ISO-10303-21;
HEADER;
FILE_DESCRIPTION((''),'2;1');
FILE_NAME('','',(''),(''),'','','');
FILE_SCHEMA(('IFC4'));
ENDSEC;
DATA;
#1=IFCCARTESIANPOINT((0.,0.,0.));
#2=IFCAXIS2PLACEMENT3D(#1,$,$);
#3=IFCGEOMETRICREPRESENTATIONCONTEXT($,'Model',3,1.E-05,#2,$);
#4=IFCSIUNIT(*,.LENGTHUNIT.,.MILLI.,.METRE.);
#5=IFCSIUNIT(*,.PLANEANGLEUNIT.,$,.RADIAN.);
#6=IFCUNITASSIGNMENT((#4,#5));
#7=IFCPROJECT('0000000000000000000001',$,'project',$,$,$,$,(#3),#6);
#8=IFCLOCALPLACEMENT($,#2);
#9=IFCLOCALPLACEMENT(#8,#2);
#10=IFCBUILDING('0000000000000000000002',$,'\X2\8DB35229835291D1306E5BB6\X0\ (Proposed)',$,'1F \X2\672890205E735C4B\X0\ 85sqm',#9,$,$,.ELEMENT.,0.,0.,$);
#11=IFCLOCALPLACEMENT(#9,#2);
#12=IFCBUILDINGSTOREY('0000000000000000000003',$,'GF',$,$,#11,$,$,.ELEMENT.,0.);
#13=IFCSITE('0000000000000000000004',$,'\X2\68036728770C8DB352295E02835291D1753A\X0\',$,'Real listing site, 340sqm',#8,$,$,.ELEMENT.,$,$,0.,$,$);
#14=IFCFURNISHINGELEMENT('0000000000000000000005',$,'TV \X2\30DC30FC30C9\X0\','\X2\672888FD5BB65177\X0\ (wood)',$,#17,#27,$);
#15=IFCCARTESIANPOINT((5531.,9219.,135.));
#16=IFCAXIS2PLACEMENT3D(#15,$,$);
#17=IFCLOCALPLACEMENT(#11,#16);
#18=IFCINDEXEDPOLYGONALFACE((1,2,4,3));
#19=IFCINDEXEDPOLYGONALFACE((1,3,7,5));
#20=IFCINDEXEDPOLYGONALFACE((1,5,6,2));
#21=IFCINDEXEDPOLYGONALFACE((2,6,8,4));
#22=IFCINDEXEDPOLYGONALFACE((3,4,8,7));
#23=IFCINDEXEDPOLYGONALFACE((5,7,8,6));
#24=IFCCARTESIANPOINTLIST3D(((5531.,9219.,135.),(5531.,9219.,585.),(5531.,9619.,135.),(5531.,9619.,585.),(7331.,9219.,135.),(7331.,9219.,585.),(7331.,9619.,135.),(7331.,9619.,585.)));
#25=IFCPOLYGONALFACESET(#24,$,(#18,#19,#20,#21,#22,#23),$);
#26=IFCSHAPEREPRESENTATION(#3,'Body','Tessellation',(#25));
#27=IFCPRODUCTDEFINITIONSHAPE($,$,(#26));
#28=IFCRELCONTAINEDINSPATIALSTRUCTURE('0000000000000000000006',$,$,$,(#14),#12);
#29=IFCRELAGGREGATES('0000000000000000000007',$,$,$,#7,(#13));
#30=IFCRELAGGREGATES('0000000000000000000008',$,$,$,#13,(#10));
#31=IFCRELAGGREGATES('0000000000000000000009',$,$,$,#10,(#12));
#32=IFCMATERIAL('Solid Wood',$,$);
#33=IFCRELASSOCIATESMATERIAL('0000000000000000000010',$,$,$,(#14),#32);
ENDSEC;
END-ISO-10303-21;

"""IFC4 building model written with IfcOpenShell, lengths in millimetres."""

from ifc_helpers import new_model, si_unit, frame, frame_2d, origin, place, context, project, spatial, rectangle, extrude, material, element, save


model = new_model("IFC4")

# Units and contexts
model_context = context("Model", 3, precision=1e-05, world=origin())
ifc_project = project(units=[si_unit("LENGTHUNIT", "METRE", prefix="MILLI"), si_unit("PLANEANGLEUNIT", "RADIAN")], contexts=[model_context])

# Site, building, storey
site_placement = place(None, origin())
site = spatial("IfcSite", under=ifc_project, at=site_placement, Name="栃木県足利市荒金町", ObjectType="Real listing site, 340sqm", CompositionType="ELEMENT", RefElevation=0.0)
building_placement = place(site_placement, origin())
building = spatial("IfcBuilding", under=site, at=building_placement, Name="足利荒金の家 (Proposed)", ObjectType="1F 木造平屋 85sqm", CompositionType="ELEMENT", ElevationOfRefHeight=0.0, ElevationOfTerrain=0.0)
storey_placement = place(building_placement, origin())
storey = spatial("IfcBuildingStorey", under=building, at=storey_placement, Name="GF", CompositionType="ELEMENT", Elevation=0.0)

# Shared definitions
ifc_material_1 = material(Name="Solid Wood")

# Furnishing element
furnishing_1_placement = place(storey_placement, frame((5531.0, 9219.0, 135.0)))
element("IfcFurnishingElement", 1, at=furnishing_1_placement, inside=storey, material=ifc_material_1, Name="TV ボード", Description="木製家具 (wood)", context=model_context, shape_type="SweptSolid", body=[
    extrude(rectangle(XDim=1800.0, YDim=400.0, at=frame_2d((900.0, 200.0))), frame((5531.0, 9219.0, 135.0)), (0.0, 0.0, 1.0), 450.0),
])

save(model, "model.ifc")
